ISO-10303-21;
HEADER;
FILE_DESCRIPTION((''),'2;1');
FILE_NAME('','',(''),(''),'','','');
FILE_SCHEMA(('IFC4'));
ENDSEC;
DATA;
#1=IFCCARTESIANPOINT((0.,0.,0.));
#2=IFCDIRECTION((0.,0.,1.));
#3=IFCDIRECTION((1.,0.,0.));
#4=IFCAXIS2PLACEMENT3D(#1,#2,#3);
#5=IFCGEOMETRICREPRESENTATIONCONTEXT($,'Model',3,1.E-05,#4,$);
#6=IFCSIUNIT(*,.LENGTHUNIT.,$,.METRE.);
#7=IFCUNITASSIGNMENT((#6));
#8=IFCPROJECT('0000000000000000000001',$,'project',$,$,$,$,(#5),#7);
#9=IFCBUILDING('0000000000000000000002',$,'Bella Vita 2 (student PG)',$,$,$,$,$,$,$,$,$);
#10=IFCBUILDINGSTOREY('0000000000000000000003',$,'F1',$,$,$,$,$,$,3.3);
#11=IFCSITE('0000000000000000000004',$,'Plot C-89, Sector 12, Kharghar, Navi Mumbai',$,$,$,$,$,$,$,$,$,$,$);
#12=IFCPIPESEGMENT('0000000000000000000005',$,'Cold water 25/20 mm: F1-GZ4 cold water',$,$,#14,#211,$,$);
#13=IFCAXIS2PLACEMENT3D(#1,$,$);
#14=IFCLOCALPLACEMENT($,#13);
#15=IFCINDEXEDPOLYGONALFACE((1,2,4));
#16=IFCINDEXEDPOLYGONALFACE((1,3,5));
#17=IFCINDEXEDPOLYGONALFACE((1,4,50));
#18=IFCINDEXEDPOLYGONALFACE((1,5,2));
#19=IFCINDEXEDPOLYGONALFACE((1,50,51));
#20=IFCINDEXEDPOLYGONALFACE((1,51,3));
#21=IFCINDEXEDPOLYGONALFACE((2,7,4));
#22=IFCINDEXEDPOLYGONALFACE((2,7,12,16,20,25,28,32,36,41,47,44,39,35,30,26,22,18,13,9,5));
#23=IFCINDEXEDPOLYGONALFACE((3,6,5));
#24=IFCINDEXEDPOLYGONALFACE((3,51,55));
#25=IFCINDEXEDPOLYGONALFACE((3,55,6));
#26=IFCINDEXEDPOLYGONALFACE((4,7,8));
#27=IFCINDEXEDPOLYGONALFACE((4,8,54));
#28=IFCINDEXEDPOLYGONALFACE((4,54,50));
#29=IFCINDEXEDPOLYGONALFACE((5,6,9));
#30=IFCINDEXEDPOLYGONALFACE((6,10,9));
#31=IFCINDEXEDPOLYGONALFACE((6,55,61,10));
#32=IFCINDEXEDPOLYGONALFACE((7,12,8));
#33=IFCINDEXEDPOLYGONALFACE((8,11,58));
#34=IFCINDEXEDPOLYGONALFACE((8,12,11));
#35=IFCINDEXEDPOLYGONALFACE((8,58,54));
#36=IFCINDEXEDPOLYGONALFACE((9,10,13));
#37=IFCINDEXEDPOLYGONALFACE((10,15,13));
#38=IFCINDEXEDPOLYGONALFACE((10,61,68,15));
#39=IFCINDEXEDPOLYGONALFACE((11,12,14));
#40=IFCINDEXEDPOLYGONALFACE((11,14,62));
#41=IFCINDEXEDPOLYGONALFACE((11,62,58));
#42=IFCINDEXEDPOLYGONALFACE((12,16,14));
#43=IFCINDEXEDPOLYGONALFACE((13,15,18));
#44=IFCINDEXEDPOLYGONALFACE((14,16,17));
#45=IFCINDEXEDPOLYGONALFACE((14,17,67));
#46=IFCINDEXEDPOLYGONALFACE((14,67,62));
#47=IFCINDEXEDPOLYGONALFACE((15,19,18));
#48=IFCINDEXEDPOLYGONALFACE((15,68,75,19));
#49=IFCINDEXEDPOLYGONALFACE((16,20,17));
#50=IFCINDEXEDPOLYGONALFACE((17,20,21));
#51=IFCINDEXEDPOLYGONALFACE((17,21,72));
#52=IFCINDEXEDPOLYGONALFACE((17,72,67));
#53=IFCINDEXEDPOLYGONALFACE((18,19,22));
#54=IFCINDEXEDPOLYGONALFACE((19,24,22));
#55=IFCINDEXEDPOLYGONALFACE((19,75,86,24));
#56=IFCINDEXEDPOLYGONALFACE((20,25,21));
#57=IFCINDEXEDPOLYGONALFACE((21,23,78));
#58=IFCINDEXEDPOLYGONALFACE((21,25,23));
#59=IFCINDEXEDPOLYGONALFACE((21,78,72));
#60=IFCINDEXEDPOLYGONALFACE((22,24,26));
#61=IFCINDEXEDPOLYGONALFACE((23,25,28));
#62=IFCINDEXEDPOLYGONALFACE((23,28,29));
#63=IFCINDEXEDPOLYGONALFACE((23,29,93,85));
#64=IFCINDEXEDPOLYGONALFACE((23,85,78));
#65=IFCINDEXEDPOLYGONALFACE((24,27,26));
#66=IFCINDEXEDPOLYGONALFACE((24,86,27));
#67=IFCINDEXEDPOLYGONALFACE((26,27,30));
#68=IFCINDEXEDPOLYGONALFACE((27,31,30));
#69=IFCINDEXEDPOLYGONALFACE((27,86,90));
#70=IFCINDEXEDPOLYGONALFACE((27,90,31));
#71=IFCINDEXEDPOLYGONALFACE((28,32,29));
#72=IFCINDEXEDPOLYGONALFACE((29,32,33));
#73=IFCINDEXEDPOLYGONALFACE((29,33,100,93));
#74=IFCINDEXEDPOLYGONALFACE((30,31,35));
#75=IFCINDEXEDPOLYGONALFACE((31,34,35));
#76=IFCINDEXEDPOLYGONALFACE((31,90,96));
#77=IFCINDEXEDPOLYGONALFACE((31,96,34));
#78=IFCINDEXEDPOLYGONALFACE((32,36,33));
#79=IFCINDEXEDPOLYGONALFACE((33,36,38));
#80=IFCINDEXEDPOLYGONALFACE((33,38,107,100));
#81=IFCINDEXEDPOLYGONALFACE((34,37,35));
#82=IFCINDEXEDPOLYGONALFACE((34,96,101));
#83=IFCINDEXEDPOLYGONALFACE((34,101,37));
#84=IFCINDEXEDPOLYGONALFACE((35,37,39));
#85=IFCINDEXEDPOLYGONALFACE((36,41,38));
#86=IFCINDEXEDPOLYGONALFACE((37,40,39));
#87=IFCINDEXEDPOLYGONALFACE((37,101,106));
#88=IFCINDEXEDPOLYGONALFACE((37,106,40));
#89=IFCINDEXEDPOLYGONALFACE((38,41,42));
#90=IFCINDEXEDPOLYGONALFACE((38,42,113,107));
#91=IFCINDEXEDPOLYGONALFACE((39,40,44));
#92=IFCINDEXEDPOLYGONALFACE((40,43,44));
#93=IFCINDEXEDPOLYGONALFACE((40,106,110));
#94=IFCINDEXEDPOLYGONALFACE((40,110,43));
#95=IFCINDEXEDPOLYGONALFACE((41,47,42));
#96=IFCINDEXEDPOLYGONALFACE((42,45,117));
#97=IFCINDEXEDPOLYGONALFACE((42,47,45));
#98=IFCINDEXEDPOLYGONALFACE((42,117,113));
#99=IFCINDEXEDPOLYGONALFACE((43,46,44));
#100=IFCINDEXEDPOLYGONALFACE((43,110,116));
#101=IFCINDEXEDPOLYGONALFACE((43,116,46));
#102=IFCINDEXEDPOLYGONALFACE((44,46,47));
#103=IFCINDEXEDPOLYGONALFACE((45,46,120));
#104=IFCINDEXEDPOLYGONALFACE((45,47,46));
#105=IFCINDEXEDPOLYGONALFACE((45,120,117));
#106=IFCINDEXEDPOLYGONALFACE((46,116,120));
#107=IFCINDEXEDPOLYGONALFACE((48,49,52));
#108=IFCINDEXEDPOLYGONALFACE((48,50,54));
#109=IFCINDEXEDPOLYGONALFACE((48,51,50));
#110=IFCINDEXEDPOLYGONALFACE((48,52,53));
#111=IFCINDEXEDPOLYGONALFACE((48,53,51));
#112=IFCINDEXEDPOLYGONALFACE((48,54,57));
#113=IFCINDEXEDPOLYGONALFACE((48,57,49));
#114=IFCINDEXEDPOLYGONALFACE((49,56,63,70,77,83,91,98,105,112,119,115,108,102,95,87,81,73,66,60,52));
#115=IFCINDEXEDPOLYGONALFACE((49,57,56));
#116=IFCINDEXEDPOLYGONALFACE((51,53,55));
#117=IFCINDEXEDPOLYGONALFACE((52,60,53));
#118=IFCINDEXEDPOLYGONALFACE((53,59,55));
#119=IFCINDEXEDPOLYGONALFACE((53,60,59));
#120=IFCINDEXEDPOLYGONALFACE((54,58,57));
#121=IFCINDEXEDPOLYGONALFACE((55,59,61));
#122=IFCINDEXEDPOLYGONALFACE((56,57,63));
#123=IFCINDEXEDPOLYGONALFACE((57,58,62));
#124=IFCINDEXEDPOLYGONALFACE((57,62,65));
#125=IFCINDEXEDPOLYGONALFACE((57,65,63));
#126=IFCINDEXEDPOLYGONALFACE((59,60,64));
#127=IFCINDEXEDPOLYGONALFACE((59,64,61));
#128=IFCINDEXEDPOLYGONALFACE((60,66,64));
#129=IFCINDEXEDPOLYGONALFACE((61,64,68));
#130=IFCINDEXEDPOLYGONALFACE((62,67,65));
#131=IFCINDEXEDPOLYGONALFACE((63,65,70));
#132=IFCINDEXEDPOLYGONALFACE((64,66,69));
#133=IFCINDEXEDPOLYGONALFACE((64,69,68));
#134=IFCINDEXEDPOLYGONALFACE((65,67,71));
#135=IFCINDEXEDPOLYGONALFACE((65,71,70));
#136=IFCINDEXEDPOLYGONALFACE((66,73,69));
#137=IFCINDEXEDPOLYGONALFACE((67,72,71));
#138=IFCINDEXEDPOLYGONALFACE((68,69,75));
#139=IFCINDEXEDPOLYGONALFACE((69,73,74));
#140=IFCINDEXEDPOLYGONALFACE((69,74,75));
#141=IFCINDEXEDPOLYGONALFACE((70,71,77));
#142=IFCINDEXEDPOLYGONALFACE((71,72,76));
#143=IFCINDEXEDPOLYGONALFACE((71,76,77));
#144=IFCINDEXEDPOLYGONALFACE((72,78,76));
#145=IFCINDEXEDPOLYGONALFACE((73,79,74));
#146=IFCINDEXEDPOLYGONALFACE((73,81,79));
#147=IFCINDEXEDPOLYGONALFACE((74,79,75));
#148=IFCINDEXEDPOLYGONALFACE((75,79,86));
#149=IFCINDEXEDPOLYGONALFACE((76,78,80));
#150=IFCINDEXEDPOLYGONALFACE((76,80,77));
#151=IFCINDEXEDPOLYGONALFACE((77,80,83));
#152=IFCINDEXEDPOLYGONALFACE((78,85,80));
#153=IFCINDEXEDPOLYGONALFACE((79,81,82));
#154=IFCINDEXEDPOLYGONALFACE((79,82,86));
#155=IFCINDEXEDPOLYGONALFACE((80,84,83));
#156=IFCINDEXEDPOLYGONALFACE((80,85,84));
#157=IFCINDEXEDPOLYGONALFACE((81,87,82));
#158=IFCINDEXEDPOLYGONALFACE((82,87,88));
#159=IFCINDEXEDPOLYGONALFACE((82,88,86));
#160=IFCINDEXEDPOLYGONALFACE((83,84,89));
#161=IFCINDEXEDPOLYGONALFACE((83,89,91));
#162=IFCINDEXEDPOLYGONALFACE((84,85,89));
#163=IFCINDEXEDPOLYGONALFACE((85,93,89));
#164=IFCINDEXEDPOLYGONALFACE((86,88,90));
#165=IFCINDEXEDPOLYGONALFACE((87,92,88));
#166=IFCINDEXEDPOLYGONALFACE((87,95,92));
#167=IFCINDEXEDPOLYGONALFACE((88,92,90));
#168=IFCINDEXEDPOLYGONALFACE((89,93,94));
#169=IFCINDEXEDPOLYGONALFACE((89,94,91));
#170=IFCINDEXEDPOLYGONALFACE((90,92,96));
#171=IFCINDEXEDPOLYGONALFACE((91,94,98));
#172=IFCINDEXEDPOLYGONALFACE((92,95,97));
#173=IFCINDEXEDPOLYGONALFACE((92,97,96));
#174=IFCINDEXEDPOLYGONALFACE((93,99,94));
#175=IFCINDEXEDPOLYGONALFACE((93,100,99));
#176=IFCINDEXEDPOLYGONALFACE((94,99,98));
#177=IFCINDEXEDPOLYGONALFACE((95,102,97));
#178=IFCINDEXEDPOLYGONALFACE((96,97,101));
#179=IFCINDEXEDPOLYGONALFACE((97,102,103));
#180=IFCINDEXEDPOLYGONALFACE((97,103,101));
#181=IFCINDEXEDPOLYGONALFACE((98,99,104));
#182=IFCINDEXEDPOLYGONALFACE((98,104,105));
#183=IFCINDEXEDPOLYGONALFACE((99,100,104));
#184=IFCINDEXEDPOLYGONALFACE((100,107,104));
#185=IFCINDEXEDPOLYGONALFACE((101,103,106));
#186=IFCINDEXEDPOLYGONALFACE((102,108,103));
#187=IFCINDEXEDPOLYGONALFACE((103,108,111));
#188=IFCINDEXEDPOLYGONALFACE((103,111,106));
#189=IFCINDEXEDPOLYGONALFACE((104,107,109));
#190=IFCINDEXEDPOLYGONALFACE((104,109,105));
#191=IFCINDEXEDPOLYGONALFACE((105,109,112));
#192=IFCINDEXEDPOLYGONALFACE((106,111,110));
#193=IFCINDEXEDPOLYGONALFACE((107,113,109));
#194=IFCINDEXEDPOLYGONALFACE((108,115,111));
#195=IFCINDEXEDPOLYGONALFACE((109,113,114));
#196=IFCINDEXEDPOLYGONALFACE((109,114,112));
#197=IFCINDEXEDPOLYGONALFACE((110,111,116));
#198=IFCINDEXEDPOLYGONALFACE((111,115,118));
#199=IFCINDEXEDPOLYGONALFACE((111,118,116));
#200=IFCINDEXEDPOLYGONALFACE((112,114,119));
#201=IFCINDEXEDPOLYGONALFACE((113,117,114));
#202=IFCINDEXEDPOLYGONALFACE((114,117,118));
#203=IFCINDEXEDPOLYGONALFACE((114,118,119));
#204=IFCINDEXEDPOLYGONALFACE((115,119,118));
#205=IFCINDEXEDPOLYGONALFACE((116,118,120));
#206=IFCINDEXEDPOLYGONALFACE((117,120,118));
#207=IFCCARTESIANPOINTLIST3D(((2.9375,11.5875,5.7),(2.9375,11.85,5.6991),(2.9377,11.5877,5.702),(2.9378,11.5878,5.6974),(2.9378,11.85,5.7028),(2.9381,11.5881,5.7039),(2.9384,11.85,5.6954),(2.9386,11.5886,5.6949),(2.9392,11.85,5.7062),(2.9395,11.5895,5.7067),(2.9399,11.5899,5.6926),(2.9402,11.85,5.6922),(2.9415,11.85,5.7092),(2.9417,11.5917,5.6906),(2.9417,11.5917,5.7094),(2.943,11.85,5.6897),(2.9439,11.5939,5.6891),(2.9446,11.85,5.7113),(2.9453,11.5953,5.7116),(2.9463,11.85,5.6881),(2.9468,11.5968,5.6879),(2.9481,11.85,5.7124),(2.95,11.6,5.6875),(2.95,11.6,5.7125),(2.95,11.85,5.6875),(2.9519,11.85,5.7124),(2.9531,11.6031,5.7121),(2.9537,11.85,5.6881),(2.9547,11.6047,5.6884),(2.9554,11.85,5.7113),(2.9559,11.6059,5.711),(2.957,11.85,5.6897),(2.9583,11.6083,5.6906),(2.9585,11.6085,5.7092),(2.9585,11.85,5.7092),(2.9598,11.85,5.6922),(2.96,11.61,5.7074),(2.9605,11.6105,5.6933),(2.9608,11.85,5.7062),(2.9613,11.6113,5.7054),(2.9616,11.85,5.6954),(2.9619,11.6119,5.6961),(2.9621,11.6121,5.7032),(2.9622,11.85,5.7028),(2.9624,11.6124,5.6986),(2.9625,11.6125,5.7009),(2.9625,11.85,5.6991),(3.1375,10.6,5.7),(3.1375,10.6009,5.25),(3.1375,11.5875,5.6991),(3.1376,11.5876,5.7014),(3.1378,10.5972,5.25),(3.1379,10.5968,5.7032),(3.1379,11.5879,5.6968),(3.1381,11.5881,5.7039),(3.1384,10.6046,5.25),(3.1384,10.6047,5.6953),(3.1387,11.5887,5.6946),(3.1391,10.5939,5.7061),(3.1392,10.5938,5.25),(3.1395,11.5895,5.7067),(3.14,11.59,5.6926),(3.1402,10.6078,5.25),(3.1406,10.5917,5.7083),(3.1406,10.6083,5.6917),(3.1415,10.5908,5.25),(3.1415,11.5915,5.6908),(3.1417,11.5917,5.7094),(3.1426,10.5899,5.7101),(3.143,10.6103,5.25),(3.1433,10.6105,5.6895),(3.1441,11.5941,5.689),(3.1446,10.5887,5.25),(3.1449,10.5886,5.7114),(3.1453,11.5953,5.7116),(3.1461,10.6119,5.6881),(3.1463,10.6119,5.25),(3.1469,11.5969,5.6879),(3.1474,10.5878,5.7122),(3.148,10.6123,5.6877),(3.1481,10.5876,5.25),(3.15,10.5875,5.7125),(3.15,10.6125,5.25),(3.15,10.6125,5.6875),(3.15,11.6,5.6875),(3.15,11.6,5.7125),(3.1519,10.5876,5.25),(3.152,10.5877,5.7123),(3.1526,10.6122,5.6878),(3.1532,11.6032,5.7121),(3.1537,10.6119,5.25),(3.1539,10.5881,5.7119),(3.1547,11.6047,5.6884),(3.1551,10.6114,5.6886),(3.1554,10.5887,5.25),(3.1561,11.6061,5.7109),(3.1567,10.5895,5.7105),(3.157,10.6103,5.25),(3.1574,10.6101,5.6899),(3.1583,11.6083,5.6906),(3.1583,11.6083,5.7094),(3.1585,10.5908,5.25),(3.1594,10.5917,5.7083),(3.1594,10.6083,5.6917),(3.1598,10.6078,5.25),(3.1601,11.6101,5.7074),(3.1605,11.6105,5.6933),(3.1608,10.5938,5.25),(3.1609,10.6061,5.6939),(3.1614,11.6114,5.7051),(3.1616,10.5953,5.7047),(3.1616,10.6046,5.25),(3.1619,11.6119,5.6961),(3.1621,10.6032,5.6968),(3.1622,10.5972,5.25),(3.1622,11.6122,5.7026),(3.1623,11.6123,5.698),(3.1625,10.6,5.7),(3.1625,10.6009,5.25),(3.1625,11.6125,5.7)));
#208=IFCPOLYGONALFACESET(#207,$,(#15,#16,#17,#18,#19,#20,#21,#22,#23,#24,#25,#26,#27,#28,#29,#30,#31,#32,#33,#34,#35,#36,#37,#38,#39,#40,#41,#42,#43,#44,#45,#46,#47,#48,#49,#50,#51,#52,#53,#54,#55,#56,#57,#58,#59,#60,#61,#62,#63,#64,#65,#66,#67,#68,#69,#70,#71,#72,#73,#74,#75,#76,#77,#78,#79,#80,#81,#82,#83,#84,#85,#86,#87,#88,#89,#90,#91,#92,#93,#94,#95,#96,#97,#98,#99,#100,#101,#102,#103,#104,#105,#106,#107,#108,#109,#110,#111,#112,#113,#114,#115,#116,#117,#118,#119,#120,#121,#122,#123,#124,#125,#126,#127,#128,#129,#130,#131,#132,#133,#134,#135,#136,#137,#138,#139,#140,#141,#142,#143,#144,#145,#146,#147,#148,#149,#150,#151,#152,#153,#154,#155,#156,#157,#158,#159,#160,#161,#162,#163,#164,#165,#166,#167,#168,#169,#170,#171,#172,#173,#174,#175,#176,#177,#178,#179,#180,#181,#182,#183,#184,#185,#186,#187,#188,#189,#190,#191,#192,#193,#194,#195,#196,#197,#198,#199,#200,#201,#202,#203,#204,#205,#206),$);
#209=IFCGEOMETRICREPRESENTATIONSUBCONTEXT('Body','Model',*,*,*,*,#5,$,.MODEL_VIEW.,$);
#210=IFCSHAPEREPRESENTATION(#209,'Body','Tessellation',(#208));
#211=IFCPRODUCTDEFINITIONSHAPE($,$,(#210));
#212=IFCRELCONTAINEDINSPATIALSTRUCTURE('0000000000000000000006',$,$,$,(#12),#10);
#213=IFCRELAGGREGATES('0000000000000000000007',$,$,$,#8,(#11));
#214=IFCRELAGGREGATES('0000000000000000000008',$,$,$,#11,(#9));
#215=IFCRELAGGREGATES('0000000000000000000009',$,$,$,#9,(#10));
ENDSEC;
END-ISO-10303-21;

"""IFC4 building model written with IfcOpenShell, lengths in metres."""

from ifc_helpers import new_model, entity, si_unit, origin, origin_with_axes, place, context, subcontext, project, spatial, element, save


model = new_model("IFC4")

# Units and contexts
model_context = context("Model", 3, precision=1e-05, world=origin_with_axes())
body_context = subcontext(model_context, "Body", "Model", "MODEL_VIEW")
ifc_project = project(units=[si_unit("LENGTHUNIT", "METRE")], contexts=[model_context])

# Site, building, storey
site = spatial("IfcSite", under=ifc_project, Name="Plot C-89, Sector 12, Kharghar, Navi Mumbai")
building = spatial("IfcBuilding", under=site, Name="Bella Vita 2 (student PG)")
storey = spatial("IfcBuildingStorey", under=building, Name="F1", Elevation=3.3)

# Pipe segment
pipe_segment_1_placement = place(None, origin())
element("IfcPipeSegment", 1, at=pipe_segment_1_placement, inside=storey, Name="Cold water 25/20 mm: F1-GZ4 cold water", context=body_context, shape_type="AdvancedSweptSolid", body=[
    entity("IfcSweptDiskSolid", entity("IfcPolyline", [entity("IfcCartesianPoint", [2.95, 11.85, 5.7]), entity("IfcCartesianPoint", [2.95, 11.6, 5.7]), entity("IfcCartesianPoint", [3.15, 11.6, 5.7]), entity("IfcCartesianPoint", [3.15, 10.6, 5.7]), entity("IfcCartesianPoint", [3.15, 10.6, 5.25])]), 0.0125),
])

save(model, "model.ifc")
